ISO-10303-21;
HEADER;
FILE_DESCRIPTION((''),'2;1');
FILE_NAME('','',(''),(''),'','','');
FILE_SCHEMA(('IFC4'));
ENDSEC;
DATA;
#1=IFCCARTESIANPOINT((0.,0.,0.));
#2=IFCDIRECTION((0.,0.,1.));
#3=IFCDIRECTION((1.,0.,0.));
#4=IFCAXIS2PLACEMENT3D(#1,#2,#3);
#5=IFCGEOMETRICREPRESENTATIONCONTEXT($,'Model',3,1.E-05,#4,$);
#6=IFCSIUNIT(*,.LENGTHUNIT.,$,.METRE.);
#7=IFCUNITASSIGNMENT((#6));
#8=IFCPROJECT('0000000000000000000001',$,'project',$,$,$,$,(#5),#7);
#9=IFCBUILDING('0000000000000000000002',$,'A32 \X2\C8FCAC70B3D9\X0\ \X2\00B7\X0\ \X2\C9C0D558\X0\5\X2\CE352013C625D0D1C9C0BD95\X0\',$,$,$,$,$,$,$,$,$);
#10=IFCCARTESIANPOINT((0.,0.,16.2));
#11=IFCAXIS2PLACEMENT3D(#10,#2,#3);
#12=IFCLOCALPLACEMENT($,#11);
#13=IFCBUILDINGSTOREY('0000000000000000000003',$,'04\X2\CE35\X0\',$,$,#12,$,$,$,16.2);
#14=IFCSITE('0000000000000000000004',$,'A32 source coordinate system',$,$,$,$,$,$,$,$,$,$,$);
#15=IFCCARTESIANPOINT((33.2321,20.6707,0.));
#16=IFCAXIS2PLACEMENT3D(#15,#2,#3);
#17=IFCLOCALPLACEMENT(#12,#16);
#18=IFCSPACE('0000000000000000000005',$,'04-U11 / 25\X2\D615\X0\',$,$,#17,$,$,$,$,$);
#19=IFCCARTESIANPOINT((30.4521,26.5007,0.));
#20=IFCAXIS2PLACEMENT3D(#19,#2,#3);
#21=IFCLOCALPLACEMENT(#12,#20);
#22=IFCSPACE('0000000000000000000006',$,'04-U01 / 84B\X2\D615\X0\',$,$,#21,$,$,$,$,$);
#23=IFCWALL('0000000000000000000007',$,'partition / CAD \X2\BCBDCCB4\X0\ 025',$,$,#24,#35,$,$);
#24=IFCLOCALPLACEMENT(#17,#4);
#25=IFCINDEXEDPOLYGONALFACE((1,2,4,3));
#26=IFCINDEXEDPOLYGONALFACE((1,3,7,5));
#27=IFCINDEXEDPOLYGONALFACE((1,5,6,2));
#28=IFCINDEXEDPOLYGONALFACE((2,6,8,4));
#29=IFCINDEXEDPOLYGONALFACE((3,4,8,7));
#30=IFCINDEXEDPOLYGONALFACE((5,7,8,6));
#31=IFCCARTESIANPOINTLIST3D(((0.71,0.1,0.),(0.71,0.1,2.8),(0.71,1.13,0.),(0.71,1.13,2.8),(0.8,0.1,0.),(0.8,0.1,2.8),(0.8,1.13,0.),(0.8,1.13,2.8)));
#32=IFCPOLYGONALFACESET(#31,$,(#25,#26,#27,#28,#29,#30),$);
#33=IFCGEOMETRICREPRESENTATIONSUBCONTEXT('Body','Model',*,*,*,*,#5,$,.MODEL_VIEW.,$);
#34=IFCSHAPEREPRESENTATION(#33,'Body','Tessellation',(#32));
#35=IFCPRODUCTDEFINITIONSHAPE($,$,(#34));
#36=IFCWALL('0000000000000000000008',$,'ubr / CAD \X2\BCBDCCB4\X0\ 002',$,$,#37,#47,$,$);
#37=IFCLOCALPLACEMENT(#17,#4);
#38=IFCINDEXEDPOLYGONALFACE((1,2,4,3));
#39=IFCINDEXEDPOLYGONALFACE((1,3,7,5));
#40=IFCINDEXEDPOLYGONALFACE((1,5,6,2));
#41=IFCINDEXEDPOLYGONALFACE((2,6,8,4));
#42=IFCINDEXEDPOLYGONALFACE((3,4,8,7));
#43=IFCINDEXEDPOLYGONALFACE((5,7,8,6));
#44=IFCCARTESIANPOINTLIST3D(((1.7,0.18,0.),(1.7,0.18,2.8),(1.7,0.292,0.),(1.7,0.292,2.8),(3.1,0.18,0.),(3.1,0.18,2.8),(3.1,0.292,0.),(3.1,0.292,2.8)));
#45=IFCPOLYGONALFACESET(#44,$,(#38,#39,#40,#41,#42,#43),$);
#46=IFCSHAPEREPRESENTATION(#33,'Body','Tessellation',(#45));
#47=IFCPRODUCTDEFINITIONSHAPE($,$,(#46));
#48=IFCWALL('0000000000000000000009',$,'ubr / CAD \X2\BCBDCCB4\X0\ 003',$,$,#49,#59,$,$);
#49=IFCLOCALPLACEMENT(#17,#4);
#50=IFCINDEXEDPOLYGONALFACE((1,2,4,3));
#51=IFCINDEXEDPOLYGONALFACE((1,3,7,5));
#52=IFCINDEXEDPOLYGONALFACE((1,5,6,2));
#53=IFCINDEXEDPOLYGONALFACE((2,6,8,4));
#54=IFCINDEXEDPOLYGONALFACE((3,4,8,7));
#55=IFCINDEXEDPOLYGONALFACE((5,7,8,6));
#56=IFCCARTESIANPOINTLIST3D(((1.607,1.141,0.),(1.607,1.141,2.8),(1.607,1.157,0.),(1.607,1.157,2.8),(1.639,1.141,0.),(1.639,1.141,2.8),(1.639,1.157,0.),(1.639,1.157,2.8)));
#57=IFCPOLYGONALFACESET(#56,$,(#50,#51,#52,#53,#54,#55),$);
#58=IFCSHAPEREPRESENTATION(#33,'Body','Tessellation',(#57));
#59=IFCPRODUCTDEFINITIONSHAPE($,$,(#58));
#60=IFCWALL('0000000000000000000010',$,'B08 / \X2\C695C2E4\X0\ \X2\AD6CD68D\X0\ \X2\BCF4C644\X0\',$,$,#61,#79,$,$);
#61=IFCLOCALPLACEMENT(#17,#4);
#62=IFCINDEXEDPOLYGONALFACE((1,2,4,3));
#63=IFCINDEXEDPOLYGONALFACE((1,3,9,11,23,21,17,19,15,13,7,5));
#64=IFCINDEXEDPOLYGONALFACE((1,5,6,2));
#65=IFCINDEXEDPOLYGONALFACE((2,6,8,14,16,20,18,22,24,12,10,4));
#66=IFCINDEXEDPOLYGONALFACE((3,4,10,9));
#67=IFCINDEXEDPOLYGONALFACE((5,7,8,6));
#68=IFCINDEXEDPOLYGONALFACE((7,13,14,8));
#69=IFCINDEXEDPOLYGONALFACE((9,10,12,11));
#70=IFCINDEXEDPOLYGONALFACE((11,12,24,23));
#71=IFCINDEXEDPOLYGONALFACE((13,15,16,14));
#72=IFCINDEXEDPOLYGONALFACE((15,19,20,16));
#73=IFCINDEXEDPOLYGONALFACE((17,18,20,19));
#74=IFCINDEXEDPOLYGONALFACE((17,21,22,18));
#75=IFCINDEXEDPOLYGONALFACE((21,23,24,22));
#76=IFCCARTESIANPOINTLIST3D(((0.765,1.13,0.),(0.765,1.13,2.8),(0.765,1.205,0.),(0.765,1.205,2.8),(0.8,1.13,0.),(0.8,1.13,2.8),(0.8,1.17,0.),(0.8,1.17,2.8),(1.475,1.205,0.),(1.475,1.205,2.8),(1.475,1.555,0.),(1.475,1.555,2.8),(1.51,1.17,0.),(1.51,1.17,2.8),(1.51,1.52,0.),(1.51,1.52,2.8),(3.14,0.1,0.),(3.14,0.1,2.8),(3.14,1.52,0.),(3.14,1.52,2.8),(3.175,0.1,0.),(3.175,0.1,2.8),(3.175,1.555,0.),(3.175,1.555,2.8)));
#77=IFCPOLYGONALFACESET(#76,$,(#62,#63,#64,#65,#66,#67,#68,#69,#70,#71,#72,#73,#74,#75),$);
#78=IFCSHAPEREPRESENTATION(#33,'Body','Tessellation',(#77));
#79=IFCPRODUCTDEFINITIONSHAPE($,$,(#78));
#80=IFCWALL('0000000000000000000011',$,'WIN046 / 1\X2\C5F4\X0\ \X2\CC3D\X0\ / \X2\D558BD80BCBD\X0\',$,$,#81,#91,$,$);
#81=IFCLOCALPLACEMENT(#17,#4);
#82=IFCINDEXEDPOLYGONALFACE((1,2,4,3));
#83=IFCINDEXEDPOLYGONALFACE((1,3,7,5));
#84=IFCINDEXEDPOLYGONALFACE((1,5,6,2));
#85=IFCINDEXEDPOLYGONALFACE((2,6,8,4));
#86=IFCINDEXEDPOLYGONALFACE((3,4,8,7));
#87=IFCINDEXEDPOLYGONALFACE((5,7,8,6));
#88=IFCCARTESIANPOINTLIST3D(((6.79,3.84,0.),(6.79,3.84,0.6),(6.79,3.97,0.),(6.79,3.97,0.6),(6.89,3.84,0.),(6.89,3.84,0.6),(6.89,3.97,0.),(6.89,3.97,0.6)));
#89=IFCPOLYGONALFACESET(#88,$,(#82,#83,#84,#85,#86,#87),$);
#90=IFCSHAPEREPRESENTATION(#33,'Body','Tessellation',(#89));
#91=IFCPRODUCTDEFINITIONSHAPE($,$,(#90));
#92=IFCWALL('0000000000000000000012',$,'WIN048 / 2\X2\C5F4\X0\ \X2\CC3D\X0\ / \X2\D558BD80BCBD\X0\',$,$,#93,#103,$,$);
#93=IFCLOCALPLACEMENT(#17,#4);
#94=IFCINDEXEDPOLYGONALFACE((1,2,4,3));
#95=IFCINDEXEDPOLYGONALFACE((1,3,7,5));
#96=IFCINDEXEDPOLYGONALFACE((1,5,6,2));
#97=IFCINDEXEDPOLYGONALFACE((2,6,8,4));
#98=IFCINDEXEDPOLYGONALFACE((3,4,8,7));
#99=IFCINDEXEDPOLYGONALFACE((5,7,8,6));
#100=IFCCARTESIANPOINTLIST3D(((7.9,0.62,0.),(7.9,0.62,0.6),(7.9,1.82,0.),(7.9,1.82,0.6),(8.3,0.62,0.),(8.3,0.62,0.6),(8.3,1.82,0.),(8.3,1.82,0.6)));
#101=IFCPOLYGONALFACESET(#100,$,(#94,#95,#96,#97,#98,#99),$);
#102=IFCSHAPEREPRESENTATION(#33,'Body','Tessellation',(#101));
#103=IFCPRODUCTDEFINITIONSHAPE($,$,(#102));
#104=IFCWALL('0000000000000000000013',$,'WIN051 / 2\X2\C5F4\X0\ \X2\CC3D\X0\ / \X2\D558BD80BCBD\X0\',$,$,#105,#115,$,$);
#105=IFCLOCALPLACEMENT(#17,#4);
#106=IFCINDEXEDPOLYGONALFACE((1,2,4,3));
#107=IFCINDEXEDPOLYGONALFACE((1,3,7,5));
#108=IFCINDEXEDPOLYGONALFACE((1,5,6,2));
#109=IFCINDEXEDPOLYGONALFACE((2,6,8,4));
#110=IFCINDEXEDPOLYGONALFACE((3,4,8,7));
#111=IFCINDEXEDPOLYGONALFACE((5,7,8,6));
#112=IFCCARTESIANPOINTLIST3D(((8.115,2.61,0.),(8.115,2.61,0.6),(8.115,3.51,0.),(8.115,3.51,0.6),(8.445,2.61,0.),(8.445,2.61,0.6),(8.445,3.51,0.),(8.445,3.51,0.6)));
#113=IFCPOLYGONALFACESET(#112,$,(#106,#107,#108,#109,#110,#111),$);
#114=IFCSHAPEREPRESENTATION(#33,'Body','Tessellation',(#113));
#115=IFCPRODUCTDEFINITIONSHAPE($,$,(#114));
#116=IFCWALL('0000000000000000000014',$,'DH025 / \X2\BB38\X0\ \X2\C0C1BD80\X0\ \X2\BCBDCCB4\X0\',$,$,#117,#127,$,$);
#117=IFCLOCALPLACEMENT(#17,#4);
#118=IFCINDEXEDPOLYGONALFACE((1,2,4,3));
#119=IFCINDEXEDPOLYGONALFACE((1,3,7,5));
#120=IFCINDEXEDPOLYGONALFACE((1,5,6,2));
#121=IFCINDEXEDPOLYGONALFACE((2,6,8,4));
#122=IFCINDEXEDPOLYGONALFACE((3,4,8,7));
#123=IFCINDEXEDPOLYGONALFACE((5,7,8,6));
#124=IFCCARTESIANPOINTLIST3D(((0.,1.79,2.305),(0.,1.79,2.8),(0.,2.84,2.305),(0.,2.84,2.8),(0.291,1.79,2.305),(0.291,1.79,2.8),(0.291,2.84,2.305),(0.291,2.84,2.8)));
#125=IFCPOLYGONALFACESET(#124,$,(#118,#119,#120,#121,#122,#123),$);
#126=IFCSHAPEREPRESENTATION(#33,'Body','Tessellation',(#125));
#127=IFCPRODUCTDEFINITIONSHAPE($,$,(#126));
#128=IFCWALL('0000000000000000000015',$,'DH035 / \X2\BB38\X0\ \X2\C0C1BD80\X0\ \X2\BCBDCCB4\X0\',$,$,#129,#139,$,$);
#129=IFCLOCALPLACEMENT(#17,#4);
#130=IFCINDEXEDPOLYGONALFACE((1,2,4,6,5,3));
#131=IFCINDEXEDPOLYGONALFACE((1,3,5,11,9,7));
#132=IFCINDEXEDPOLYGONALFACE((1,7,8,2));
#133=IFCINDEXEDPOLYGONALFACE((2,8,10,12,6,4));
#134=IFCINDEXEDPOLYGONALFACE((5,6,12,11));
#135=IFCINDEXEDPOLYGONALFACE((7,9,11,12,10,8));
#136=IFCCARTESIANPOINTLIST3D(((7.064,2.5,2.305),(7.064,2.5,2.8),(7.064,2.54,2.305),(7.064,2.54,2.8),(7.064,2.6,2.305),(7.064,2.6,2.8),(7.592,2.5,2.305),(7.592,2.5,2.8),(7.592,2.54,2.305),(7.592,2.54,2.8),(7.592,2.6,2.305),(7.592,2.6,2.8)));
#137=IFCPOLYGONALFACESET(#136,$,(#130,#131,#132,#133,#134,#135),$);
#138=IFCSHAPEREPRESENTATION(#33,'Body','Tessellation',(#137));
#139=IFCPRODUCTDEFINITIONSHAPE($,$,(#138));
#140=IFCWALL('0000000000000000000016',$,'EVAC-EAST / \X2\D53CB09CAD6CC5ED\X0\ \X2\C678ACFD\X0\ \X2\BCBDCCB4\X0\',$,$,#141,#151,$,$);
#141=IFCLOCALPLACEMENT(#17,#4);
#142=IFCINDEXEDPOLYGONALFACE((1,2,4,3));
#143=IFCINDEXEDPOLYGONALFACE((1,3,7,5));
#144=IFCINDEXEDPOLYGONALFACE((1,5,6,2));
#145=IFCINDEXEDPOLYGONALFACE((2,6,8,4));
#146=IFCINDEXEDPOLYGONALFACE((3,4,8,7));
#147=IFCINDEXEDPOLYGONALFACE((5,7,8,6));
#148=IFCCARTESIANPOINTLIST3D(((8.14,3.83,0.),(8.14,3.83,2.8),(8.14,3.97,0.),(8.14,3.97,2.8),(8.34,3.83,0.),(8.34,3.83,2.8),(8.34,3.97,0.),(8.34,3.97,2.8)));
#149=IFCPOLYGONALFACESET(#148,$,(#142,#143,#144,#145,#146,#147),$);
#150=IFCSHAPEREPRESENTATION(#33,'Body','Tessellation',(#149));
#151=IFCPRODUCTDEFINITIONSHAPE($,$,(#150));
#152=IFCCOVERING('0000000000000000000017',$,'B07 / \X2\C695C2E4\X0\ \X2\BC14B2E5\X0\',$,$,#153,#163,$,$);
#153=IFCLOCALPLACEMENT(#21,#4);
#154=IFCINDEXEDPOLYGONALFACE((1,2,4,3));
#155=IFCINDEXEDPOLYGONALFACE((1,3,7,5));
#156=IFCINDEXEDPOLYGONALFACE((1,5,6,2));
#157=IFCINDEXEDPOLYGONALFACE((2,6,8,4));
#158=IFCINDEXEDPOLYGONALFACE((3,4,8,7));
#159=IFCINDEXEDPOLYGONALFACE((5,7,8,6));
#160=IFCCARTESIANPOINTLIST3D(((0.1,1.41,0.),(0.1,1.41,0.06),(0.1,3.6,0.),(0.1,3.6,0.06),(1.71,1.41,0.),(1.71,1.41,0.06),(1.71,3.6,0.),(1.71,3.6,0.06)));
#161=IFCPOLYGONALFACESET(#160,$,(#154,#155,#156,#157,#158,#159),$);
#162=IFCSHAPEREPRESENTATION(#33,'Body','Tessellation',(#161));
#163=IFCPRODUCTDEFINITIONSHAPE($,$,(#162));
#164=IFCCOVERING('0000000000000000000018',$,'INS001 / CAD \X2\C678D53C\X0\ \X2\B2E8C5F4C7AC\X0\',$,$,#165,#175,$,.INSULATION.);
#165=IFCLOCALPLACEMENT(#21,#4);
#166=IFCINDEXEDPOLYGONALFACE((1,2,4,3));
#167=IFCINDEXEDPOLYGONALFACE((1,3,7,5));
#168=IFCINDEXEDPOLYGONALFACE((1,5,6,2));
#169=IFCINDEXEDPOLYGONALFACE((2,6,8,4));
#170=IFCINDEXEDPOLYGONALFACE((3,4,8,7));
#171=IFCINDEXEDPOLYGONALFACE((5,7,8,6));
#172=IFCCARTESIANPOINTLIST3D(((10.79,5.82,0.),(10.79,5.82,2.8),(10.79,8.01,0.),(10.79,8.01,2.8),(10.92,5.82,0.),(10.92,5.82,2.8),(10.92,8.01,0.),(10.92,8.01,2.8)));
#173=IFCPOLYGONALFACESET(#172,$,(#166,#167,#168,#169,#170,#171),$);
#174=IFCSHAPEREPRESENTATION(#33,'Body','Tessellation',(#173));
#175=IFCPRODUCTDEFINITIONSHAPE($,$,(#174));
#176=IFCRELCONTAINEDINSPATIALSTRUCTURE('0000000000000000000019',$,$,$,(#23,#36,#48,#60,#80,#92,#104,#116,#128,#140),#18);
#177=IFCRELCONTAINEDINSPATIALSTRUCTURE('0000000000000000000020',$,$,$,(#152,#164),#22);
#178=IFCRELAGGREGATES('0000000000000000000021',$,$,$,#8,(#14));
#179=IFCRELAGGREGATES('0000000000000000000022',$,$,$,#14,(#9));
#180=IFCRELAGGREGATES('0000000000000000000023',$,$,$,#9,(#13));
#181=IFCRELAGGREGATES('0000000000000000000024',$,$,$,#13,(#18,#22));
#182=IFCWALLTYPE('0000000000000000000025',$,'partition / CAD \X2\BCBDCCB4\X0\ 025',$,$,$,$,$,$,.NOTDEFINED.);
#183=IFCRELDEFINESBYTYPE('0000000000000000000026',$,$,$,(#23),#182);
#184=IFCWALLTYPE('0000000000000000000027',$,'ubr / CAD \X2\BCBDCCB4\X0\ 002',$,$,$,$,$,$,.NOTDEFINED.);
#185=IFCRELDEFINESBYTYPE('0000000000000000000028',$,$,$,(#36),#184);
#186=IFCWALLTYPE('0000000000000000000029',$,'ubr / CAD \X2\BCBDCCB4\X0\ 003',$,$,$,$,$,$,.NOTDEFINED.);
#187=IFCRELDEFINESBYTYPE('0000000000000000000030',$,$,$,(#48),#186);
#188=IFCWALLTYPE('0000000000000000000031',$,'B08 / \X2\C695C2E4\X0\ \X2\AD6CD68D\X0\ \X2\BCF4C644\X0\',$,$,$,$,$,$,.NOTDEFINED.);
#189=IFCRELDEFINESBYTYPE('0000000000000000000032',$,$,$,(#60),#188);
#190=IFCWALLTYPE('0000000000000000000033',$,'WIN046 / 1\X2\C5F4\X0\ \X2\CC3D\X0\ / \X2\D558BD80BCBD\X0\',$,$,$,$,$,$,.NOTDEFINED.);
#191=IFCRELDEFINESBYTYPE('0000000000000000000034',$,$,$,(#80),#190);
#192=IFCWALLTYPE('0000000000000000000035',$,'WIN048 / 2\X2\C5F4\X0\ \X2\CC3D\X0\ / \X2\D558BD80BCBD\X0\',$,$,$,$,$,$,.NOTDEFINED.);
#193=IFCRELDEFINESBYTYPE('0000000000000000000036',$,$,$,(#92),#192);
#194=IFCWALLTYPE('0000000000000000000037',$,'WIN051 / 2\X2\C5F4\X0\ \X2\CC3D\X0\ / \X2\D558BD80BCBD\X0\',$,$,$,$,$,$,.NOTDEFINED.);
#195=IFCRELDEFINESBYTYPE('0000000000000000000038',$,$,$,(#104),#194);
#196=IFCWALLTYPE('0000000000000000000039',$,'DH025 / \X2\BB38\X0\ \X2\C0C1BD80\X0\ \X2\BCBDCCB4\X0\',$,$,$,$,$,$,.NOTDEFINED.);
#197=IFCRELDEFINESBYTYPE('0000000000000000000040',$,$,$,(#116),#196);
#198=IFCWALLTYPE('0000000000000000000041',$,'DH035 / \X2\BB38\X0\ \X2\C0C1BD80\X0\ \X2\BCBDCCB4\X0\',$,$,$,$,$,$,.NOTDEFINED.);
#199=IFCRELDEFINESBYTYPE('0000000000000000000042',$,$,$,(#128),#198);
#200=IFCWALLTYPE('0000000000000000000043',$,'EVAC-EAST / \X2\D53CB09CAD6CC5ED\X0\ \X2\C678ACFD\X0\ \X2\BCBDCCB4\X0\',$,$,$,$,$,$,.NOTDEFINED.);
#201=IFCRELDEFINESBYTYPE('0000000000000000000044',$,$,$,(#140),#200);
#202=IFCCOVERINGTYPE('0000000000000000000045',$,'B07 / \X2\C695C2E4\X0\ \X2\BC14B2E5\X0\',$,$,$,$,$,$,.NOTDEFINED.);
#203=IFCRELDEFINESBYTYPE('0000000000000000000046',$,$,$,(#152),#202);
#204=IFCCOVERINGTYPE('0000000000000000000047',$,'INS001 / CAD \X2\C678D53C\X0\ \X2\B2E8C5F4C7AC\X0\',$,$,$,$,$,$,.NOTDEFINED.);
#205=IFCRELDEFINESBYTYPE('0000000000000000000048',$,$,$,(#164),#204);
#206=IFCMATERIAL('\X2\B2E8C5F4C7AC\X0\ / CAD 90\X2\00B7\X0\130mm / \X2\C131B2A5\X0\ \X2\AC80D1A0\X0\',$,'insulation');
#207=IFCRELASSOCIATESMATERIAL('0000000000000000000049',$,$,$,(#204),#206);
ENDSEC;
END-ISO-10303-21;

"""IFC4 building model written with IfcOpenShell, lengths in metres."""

from ifc_helpers import new_model, si_unit, frame, origin, origin_with_axes, place, context, subcontext, project, spatial, polyline, outline, extrude, source, transform, mapped, material, type_object, type_shapes, element, save


model = new_model("IFC4")

# Units and contexts
model_context = context("Model", 3, precision=1e-05, world=origin_with_axes())
body_context = subcontext(model_context, "Body", "Model", "MODEL_VIEW")
ifc_project = project(units=[si_unit("LENGTHUNIT", "METRE")], contexts=[model_context])

# Site, building, storey, space
site = spatial("IfcSite", under=ifc_project, Name="A32 source coordinate system")
building = spatial("IfcBuilding", under=site, Name="A32 주거동 · 지하5층–옥탑지붕")
storey_placement = place(None, frame((0.0, 0.0, 16.2), z_axis=(0.0, 0.0, 1.0), x_axis=(1.0, 0.0, 0.0)))
storey = spatial("IfcBuildingStorey", under=building, at=storey_placement, Name="04층", Elevation=16.2)
space_1_placement = place(storey_placement, frame((33.2321, 20.6707, 0.0), z_axis=(0.0, 0.0, 1.0), x_axis=(1.0, 0.0, 0.0)))
space_1 = spatial("IfcSpace", under=storey, at=space_1_placement, Name="04-U11 / 25형")

# Walls
wall_type_1 = type_object("IfcWallType", Name="partition / CAD 벽체 025", PredefinedType="NOTDEFINED")
shared_shape_1 = source(origin(), body_context, "Body", "SweptSolid", [
    extrude(outline(polyline([(0.71, 1.13), (0.8, 1.13), (0.8, 0.1), (0.71, 0.1), (0.71, 1.13)])), origin(), (0.0, 0.0, 1.0), 2.8),
])
type_shapes(wall_type_1, [shared_shape_1])
wall_1_placement = place(space_1_placement, origin_with_axes())
element("IfcWall", 1, at=wall_1_placement, inside=space_1, type_object=wall_type_1, Name="partition / CAD 벽체 025", context=body_context, shape_type="MappedRepresentation", body=[
    mapped(shared_shape_1, transform((0.0, 0.0, 0.0), scale=1.0)),
])
wall_type_2 = type_object("IfcWallType", Name="ubr / CAD 벽체 002", PredefinedType="NOTDEFINED")
shared_shape_2 = source(origin(), body_context, "Body", "SweptSolid", [
    extrude(outline(polyline([(3.1, 0.292), (3.1, 0.18), (1.7, 0.18), (1.7, 0.292), (3.1, 0.292)])), origin(), (0.0, 0.0, 1.0), 2.8),
])
type_shapes(wall_type_2, [shared_shape_2])
wall_2_placement = place(space_1_placement, origin_with_axes())
element("IfcWall", 2, at=wall_2_placement, inside=space_1, type_object=wall_type_2, Name="ubr / CAD 벽체 002", context=body_context, shape_type="MappedRepresentation", body=[
    mapped(shared_shape_2, transform((0.0, 0.0, 0.0), scale=1.0)),
])
wall_type_3 = type_object("IfcWallType", Name="ubr / CAD 벽체 003", PredefinedType="NOTDEFINED")
shared_shape_3 = source(origin(), body_context, "Body", "SweptSolid", [
    extrude(outline(polyline([(1.639, 1.157), (1.639, 1.141), (1.607, 1.141), (1.607, 1.157), (1.639, 1.157)])), origin(), (0.0, 0.0, 1.0), 2.8),
])
type_shapes(wall_type_3, [shared_shape_3])
wall_3_placement = place(space_1_placement, origin_with_axes())
element("IfcWall", 3, at=wall_3_placement, inside=space_1, type_object=wall_type_3, Name="ubr / CAD 벽체 003", context=body_context, shape_type="MappedRepresentation", body=[
    mapped(shared_shape_3, transform((0.0, 0.0, 0.0), scale=1.0)),
])
wall_type_4 = type_object("IfcWallType", Name="B08 / 욕실 구획 보완", PredefinedType="NOTDEFINED")
shared_shape_4 = source(origin(), body_context, "Body", "SweptSolid", [
    extrude(outline(polyline([(0.765, 1.205), (1.475, 1.205), (1.475, 1.555), (3.175, 1.555), (3.175, 0.1), (3.14, 0.1), (3.14, 1.52), (1.51, 1.52), (1.51, 1.17), (0.8, 1.17), (0.8, 1.13), (0.765, 1.13), (0.765, 1.205)])), origin(), (0.0, 0.0, 1.0), 2.8),
])
type_shapes(wall_type_4, [shared_shape_4])
wall_4_placement = place(space_1_placement, origin_with_axes())
element("IfcWall", 4, at=wall_4_placement, inside=space_1, type_object=wall_type_4, Name="B08 / 욕실 구획 보완", context=body_context, shape_type="MappedRepresentation", body=[
    mapped(shared_shape_4, transform((0.0, 0.0, 0.0), scale=1.0)),
])
wall_type_5 = type_object("IfcWallType", Name="WIN046 / 1열 창 / 하부벽", PredefinedType="NOTDEFINED")
shared_shape_5 = source(origin(), body_context, "Body", "SweptSolid", [
    extrude(outline(polyline([(6.89, 3.84), (6.79, 3.84), (6.79, 3.97), (6.89, 3.97), (6.89, 3.84)])), origin(), (0.0, 0.0, 1.0), 0.6),
])
type_shapes(wall_type_5, [shared_shape_5])
wall_5_placement = place(space_1_placement, origin_with_axes())
element("IfcWall", 5, at=wall_5_placement, inside=space_1, type_object=wall_type_5, Name="WIN046 / 1열 창 / 하부벽", context=body_context, shape_type="MappedRepresentation", body=[
    mapped(shared_shape_5, transform((0.0, 0.0, 0.0), scale=1.0)),
])
wall_type_6 = type_object("IfcWallType", Name="WIN048 / 2열 창 / 하부벽", PredefinedType="NOTDEFINED")
shared_shape_6 = source(origin(), body_context, "Body", "SweptSolid", [
    extrude(outline(polyline([(8.3, 0.62), (7.9, 0.62), (7.9, 1.82), (8.3, 1.82), (8.3, 0.62)])), origin(), (0.0, 0.0, 1.0), 0.6),
])
type_shapes(wall_type_6, [shared_shape_6])
wall_6_placement = place(space_1_placement, origin_with_axes())
element("IfcWall", 6, at=wall_6_placement, inside=space_1, type_object=wall_type_6, Name="WIN048 / 2열 창 / 하부벽", context=body_context, shape_type="MappedRepresentation", body=[
    mapped(shared_shape_6, transform((0.0, 0.0, 0.0), scale=1.0)),
])
wall_type_7 = type_object("IfcWallType", Name="WIN051 / 2열 창 / 하부벽", PredefinedType="NOTDEFINED")
shared_shape_7 = source(origin(), body_context, "Body", "SweptSolid", [
    extrude(outline(polyline([(8.445, 2.61), (8.115, 2.61), (8.115, 3.51), (8.445, 3.51), (8.445, 2.61)])), origin(), (0.0, 0.0, 1.0), 0.6),
])
type_shapes(wall_type_7, [shared_shape_7])
wall_7_placement = place(space_1_placement, origin_with_axes())
element("IfcWall", 7, at=wall_7_placement, inside=space_1, type_object=wall_type_7, Name="WIN051 / 2열 창 / 하부벽", context=body_context, shape_type="MappedRepresentation", body=[
    mapped(shared_shape_7, transform((0.0, 0.0, 0.0), scale=1.0)),
])
wall_type_8 = type_object("IfcWallType", Name="DH025 / 문 상부 벽체", PredefinedType="NOTDEFINED")
shared_shape_8 = source(origin(), body_context, "Body", "SweptSolid", [
    extrude(outline(polyline([(0.0, 1.79), (0.0, 2.84), (0.291, 2.84), (0.291, 1.79), (0.0, 1.79)])), frame((0.0, 0.0, 2.305)), (0.0, 0.0, 1.0), 0.495),
])
type_shapes(wall_type_8, [shared_shape_8])
wall_8_placement = place(space_1_placement, origin_with_axes())
element("IfcWall", 8, at=wall_8_placement, inside=space_1, type_object=wall_type_8, Name="DH025 / 문 상부 벽체", context=body_context, shape_type="MappedRepresentation", body=[
    mapped(shared_shape_8, transform((0.0, 0.0, 0.0), scale=1.0)),
])
wall_type_9 = type_object("IfcWallType", Name="DH035 / 문 상부 벽체", PredefinedType="NOTDEFINED")
shared_shape_9 = source(origin(), body_context, "Body", "SweptSolid", [
    extrude(outline(polyline([(7.592, 2.6), (7.592, 2.54), (7.592, 2.5), (7.064, 2.5), (7.064, 2.54), (7.064, 2.6), (7.592, 2.6)])), frame((0.0, 0.0, 2.305)), (0.0, 0.0, 1.0), 0.495),
])
type_shapes(wall_type_9, [shared_shape_9])
wall_9_placement = place(space_1_placement, origin_with_axes())
element("IfcWall", 9, at=wall_9_placement, inside=space_1, type_object=wall_type_9, Name="DH035 / 문 상부 벽체", context=body_context, shape_type="MappedRepresentation", body=[
    mapped(shared_shape_9, transform((0.0, 0.0, 0.0), scale=1.0)),
])
wall_type_10 = type_object("IfcWallType", Name="EVAC-EAST / 피난구역 외곽 벽체", PredefinedType="NOTDEFINED")
shared_shape_10 = source(origin(), body_context, "Body", "SweptSolid", [
    extrude(outline(polyline([(8.34, 3.83), (8.14, 3.83), (8.14, 3.97), (8.34, 3.97), (8.34, 3.83)])), origin(), (0.0, 0.0, 1.0), 2.8),
])
type_shapes(wall_type_10, [shared_shape_10])
wall_10_placement = place(space_1_placement, origin_with_axes())
element("IfcWall", 10, at=wall_10_placement, inside=space_1, type_object=wall_type_10, Name="EVAC-EAST / 피난구역 외곽 벽체", context=body_context, shape_type="MappedRepresentation", body=[
    mapped(shared_shape_10, transform((0.0, 0.0, 0.0), scale=1.0)),
])

# Shared definitions
space_2_placement = place(storey_placement, frame((30.4521, 26.5007, 0.0), z_axis=(0.0, 0.0, 1.0), x_axis=(1.0, 0.0, 0.0)))
space_2 = spatial("IfcSpace", under=storey, at=space_2_placement, Name="04-U01 / 84B형")

# Coverings
covering_type_1 = type_object("IfcCoveringType", Name="B07 / 욕실 바닥", PredefinedType="NOTDEFINED")
shared_shape_11 = source(origin(), body_context, "Body", "SweptSolid", [
    extrude(outline(polyline([(1.71, 1.41), (0.1, 1.41), (0.1, 3.6), (1.71, 3.6), (1.71, 1.41)])), origin(), (0.0, 0.0, 1.0), 0.06),
])
type_shapes(covering_type_1, [shared_shape_11])
covering_1_placement = place(space_2_placement, origin_with_axes())
element("IfcCovering", 11, at=covering_1_placement, inside=space_2, type_object=covering_type_1, Name="B07 / 욕실 바닥", context=body_context, shape_type="MappedRepresentation", body=[
    mapped(shared_shape_11, transform((0.0, 0.0, 0.0), scale=1.0)),
])
ifc_material = material(Name="단열재 / CAD 90·130mm / 성능 검토", Category="insulation")
covering_type_2 = type_object("IfcCoveringType", Name="INS001 / CAD 외피 단열재", PredefinedType="NOTDEFINED", material=ifc_material)
shared_shape_12 = source(origin(), body_context, "Body", "SweptSolid", [
    extrude(outline(polyline([(10.79, 5.82), (10.79, 8.01), (10.92, 8.01), (10.92, 5.82), (10.79, 5.82)])), origin(), (0.0, 0.0, 1.0), 2.8),
])
type_shapes(covering_type_2, [shared_shape_12])
covering_2_placement = place(space_2_placement, origin_with_axes())
element("IfcCovering", 12, at=covering_2_placement, inside=space_2, type_object=covering_type_2, Name="INS001 / CAD 외피 단열재", PredefinedType="INSULATION", context=body_context, shape_type="MappedRepresentation", body=[
    mapped(shared_shape_12, transform((0.0, 0.0, 0.0), scale=1.0)),
])

save(model, "model.ifc")
